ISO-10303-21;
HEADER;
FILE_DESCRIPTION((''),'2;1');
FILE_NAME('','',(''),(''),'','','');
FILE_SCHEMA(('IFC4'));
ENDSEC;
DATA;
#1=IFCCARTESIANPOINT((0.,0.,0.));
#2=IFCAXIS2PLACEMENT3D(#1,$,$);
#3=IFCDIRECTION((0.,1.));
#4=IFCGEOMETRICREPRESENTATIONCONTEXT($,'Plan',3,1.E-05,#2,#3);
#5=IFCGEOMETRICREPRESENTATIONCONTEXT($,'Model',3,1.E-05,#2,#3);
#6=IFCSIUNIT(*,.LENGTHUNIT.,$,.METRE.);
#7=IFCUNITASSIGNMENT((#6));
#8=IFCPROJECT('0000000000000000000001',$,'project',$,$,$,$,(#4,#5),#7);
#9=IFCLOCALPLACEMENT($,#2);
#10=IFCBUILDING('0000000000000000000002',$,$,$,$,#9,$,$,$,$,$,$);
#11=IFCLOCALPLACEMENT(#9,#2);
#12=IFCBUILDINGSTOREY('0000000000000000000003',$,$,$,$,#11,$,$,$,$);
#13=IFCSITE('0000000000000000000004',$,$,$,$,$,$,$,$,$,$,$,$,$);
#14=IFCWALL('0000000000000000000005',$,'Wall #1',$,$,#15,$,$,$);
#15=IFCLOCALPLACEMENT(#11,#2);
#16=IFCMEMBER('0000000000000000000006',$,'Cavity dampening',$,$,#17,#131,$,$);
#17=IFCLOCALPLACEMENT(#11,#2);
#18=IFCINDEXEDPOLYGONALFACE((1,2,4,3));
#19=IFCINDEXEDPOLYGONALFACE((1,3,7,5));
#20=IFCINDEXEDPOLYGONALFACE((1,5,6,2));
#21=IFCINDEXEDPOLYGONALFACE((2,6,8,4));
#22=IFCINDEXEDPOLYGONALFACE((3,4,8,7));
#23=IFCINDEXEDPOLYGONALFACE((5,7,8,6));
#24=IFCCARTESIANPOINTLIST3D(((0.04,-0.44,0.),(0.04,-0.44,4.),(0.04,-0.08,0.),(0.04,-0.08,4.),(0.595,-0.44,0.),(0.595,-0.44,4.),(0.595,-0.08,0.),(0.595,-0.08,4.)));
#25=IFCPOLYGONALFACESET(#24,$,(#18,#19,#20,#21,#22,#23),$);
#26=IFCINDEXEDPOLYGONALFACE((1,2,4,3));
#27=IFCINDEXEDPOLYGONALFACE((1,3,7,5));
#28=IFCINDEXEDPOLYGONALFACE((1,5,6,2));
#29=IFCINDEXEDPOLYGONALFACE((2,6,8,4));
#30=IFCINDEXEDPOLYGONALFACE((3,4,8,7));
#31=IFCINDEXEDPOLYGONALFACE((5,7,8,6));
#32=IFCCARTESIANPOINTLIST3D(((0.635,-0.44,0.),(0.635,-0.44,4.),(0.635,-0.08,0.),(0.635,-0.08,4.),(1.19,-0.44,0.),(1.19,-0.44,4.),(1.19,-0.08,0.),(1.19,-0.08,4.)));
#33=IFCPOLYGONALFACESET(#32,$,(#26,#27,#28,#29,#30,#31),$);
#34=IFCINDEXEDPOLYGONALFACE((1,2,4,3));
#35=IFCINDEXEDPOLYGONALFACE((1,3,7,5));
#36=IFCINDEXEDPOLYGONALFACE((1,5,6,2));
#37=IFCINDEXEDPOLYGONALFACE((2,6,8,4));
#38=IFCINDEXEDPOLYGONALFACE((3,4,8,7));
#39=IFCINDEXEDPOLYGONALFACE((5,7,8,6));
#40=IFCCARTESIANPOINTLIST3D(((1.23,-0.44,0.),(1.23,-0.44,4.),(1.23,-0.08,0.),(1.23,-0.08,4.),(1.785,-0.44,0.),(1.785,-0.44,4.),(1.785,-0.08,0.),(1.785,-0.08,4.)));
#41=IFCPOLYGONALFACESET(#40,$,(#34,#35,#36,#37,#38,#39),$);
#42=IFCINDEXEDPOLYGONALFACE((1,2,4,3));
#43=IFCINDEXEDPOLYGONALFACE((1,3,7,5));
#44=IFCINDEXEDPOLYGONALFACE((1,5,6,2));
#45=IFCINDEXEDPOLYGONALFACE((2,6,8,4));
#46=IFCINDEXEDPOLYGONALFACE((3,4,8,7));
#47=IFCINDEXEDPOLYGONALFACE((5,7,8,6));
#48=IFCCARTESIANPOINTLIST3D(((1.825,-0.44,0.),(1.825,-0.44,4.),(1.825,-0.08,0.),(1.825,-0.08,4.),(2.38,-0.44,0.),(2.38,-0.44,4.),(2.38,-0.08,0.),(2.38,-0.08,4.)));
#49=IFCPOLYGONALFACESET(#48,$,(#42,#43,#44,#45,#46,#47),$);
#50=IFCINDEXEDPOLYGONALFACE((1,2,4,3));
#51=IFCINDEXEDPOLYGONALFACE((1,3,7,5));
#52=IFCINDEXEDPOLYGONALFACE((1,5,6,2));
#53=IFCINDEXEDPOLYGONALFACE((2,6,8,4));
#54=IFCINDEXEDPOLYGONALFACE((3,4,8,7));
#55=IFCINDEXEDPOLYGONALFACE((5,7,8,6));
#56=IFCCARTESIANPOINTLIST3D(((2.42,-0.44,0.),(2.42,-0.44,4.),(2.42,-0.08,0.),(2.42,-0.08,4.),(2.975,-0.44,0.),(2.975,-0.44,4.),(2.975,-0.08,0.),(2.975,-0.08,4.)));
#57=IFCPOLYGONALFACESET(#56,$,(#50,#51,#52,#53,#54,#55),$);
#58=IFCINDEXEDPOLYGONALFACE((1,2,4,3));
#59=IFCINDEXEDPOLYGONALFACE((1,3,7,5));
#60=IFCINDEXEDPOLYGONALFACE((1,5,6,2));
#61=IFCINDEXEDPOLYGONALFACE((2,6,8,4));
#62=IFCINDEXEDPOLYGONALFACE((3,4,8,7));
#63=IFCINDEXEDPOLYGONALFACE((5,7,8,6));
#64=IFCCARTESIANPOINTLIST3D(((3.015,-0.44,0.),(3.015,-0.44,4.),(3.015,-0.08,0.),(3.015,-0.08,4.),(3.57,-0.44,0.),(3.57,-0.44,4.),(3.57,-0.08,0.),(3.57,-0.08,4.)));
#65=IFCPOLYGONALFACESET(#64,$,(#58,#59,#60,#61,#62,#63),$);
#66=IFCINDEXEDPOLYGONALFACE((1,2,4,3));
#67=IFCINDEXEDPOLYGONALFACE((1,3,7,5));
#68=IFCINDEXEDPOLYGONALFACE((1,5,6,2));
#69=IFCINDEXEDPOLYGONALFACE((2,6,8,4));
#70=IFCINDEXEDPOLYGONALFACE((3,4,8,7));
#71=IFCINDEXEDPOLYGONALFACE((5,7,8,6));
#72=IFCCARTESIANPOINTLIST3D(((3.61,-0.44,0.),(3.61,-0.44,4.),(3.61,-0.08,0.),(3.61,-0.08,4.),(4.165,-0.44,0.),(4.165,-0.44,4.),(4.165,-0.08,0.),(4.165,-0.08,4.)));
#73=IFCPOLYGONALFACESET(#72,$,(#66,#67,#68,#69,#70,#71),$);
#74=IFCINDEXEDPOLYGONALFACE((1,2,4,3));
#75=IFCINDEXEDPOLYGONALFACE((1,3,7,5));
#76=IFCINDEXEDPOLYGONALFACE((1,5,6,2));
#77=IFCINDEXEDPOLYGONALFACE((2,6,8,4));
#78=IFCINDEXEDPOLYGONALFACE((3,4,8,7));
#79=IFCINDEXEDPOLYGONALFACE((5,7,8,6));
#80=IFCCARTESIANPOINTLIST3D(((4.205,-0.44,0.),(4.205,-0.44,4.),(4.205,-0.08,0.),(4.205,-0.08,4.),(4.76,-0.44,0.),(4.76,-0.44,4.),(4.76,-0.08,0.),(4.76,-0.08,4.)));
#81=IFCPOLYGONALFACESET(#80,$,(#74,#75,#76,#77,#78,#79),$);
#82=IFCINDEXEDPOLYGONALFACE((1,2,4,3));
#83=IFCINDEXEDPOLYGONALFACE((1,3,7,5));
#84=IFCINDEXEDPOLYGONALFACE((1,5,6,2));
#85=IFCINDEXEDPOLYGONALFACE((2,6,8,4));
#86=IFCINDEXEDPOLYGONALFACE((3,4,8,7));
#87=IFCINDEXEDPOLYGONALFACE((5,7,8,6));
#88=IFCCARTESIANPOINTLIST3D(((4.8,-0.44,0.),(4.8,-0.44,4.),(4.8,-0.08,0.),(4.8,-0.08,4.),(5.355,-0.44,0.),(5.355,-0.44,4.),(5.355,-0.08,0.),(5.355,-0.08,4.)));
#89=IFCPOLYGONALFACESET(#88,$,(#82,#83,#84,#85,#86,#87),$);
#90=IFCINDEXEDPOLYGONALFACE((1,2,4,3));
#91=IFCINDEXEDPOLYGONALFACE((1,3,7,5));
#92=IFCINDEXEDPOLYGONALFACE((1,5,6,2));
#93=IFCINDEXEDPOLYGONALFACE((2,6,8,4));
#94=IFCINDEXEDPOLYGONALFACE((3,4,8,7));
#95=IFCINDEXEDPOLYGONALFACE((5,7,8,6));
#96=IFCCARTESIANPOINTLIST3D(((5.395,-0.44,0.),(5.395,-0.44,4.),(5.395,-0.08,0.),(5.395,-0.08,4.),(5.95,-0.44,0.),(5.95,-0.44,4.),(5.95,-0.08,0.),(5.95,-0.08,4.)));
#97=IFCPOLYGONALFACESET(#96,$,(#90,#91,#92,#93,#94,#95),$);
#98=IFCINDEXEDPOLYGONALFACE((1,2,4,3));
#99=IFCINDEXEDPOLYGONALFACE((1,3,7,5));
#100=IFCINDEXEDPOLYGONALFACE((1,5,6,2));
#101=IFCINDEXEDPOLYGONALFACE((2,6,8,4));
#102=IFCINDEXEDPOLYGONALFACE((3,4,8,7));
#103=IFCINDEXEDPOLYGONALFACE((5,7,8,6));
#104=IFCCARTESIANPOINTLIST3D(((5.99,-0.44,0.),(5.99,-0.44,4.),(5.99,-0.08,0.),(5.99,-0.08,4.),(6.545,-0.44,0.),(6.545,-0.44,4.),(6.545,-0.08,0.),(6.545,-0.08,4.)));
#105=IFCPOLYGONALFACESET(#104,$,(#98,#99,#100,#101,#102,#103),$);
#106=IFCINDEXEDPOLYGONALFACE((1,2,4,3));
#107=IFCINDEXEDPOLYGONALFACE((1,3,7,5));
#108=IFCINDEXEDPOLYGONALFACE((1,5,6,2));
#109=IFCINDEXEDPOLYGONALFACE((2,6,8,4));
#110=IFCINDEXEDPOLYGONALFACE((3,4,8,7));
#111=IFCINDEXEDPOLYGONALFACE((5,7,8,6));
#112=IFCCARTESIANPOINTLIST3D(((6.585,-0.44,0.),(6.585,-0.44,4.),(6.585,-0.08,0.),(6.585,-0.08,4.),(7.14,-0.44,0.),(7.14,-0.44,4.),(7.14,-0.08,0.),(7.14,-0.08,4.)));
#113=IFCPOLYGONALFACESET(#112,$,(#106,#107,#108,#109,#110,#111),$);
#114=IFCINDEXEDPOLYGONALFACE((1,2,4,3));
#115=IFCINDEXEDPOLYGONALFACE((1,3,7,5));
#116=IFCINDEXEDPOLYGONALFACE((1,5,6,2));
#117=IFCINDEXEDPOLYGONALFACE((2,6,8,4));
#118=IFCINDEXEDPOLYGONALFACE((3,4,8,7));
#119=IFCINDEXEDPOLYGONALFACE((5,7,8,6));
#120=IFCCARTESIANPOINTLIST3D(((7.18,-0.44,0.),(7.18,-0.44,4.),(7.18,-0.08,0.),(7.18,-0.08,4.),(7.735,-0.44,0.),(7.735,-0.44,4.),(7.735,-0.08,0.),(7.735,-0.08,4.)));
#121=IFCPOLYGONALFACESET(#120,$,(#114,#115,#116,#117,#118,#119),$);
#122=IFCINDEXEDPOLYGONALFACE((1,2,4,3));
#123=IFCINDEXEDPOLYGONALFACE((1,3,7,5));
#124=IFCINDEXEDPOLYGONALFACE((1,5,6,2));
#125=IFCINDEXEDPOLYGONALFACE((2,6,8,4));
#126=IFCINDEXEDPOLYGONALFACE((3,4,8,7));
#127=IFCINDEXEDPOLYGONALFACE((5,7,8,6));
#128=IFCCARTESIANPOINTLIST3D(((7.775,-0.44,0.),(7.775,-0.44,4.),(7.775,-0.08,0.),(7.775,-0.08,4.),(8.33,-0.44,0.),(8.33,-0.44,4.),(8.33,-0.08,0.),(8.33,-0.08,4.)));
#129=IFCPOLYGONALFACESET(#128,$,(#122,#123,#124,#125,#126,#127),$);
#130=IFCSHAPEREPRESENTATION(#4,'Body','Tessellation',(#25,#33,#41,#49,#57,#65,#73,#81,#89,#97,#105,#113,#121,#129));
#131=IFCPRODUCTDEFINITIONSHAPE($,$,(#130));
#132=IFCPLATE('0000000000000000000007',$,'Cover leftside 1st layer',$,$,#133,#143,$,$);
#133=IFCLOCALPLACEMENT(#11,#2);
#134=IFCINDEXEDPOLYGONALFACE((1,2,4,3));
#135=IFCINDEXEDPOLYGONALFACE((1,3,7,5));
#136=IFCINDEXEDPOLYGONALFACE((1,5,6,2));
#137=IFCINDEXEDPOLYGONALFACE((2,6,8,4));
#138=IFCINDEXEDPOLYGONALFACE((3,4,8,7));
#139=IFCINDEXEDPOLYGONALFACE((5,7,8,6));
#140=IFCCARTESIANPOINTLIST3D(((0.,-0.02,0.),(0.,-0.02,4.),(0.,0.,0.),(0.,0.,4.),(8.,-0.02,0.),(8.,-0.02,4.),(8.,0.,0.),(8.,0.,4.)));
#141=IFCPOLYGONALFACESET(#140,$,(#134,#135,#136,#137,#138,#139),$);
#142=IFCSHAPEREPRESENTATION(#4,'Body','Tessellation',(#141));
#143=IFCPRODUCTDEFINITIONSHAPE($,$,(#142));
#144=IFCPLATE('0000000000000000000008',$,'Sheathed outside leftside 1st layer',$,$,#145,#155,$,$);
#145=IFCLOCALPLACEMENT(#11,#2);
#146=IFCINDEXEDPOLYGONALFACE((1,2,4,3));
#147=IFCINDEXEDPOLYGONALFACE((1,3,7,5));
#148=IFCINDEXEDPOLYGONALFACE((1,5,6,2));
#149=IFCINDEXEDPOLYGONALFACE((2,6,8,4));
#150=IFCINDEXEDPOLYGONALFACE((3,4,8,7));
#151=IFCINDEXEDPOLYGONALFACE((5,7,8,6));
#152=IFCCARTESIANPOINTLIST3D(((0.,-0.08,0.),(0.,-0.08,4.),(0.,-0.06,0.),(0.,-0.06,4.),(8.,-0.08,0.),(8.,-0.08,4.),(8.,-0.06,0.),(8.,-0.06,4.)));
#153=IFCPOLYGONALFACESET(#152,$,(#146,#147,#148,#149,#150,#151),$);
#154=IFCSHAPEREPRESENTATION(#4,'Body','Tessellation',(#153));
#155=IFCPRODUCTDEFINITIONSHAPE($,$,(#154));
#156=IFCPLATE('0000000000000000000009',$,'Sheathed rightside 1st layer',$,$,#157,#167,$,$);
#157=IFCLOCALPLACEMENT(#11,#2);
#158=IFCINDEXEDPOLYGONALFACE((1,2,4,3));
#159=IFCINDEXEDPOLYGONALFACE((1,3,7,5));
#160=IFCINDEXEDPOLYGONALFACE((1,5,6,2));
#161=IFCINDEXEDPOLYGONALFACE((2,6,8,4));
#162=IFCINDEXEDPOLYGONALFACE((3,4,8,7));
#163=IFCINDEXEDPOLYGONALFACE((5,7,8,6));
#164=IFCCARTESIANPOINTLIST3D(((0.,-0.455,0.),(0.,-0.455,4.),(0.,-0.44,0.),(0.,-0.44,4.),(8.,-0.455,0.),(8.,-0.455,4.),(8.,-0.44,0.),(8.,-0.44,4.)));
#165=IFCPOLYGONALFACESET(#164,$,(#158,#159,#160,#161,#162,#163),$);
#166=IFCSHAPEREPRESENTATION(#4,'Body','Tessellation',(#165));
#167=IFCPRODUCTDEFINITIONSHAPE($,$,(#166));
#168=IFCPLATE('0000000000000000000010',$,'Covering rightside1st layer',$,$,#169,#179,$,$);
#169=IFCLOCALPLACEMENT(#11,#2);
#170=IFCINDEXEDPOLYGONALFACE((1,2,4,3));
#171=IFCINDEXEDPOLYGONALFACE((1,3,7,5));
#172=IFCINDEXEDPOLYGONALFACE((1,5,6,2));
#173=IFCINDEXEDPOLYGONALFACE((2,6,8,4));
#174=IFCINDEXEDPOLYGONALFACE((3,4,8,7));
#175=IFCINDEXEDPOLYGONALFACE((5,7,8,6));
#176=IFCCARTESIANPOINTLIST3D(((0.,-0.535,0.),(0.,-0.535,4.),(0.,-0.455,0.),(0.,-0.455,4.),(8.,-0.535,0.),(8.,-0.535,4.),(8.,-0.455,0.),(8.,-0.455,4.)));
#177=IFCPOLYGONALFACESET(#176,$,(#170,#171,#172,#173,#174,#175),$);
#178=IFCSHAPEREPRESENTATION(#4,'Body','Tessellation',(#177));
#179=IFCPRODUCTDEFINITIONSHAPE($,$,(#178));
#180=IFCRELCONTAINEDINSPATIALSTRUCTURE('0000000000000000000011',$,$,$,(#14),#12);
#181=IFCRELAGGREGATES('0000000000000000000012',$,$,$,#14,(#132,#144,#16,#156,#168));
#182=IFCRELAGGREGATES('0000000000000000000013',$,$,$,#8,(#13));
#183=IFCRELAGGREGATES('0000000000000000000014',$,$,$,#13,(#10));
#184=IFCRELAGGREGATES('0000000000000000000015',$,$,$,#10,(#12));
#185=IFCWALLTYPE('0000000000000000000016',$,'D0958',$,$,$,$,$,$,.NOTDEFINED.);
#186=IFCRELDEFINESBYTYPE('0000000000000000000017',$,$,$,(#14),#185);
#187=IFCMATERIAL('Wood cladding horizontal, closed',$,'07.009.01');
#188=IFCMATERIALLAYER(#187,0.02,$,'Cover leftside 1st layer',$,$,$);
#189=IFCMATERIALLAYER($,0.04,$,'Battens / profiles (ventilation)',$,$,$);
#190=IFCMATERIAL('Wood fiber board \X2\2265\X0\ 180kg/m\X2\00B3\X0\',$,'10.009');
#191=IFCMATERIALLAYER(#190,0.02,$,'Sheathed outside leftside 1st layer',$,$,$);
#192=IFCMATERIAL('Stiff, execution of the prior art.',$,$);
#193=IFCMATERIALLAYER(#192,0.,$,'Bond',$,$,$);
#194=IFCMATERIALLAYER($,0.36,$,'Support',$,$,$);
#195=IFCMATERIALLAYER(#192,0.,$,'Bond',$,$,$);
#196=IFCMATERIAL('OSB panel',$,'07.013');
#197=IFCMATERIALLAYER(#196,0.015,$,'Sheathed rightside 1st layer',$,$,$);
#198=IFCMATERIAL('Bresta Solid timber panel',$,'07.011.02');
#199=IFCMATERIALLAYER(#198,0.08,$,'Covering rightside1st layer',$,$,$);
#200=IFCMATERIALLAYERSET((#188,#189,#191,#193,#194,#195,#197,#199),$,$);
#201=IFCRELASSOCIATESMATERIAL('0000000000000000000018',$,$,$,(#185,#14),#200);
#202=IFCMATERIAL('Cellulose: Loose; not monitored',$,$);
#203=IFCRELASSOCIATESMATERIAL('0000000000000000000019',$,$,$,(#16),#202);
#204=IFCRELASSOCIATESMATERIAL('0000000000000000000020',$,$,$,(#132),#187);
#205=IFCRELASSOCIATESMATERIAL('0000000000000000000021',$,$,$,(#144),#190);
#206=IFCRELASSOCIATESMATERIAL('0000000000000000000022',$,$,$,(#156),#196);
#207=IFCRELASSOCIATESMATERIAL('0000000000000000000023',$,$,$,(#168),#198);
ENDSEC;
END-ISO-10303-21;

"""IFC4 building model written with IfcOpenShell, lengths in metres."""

from ifc_helpers import new_model, si_unit, direction, frame, frame_2d, origin, origin_with_axes, place, context, project, spatial, rectangle, extrude, material, layer, layer_set, type_object, element, aggregate, save


model = new_model("IFC4")

# Units and contexts
plan_context = context("Plan", 3, precision=1e-05, world=origin(), true_north=direction((0.0, 1.0)))
model_context = context("Model", 3, precision=1e-05, world=origin(), true_north=direction((0.0, 1.0)))
ifc_project = project(units=[si_unit("LENGTHUNIT", "METRE")], contexts=[plan_context, model_context])

# Site, building, storey
site = spatial("IfcSite", under=ifc_project)
building_placement = place(None, origin())
building = spatial("IfcBuilding", under=site, at=building_placement)
storey_placement = place(building_placement, origin())
storey = spatial("IfcBuildingStorey", under=building, at=storey_placement)

# Wall, member, plates
ifc_material_1 = material(Name="Wood cladding horizontal, closed", Category="07.009.01")
ifc_layer_1 = layer(ifc_material_1, 0.02, Name="Cover leftside 1st layer")
ifc_layer_2 = layer(None, 0.04, Name="Battens / profiles (ventilation)")
ifc_material_2 = material(Name="Wood fiber board ≥ 180kg/m³", Category="10.009")
ifc_layer_3 = layer(ifc_material_2, 0.02, Name="Sheathed outside leftside 1st layer")
ifc_material_3 = material(Name="Stiff, execution of the prior art.")
ifc_layer_4 = layer(ifc_material_3, 0.0, Name="Bond")
ifc_layer_5 = layer(None, 0.36, Name="Support")
ifc_layer_6 = layer(ifc_material_3, 0.0, Name="Bond")
ifc_material_4 = material(Name="OSB panel", Category="07.013")
ifc_layer_7 = layer(ifc_material_4, 0.015, Name="Sheathed rightside 1st layer")
ifc_material_5 = material(Name="Bresta Solid timber panel", Category="07.011.02")
ifc_layer_8 = layer(ifc_material_5, 0.08, Name="Covering rightside1st layer")
ifc_layer_set = layer_set([ifc_layer_1, ifc_layer_2, ifc_layer_3, ifc_layer_4, ifc_layer_5, ifc_layer_6, ifc_layer_7, ifc_layer_8])
wall_type = type_object("IfcWallType", Name="D0958", PredefinedType="NOTDEFINED", material=ifc_layer_set)
wall_placement = place(None, frame((0.0, 0.0, 0.0), z_axis=(0.0, -1.0, 0.0), x_axis=(1.0, 0.0, 0.0)))
wall = element("IfcWall", 1, at=wall_placement, inside=storey, type_object=wall_type, material=ifc_layer_set, Name="Wall #1")
ifc_material_6 = material(Name="Cellulose: Loose; not monitored")
member_1_placement = place(wall_placement, origin())
member_1 = element("IfcMember", 2, at=member_1_placement, material=ifc_material_6, Name="Cavity dampening", context=plan_context, shape_type="SweptSolid", body=[
    extrude(rectangle(XDim=0.555, YDim=0.36, at=frame_2d((0.2775, 0.18), x_axis=(1.0, 0.0))), frame((0.04, 4.0, 0.08), z_axis=(0.0, -1.0, 0.0), x_axis=(1.0, 0.0, 0.0)), (0.0, 0.0, 1.0), 4.0),
    extrude(rectangle(XDim=0.555, YDim=0.36, at=frame_2d((0.2775, 0.18), x_axis=(1.0, 0.0))), frame((0.635, 4.0, 0.08), z_axis=(0.0, -1.0, 0.0), x_axis=(1.0, 0.0, 0.0)), (0.0, 0.0, 1.0), 4.0),
    extrude(rectangle(XDim=0.555, YDim=0.36, at=frame_2d((0.2775, 0.18), x_axis=(1.0, 0.0))), frame((1.23, 4.0, 0.08), z_axis=(0.0, -1.0, 0.0), x_axis=(1.0, 0.0, 0.0)), (0.0, 0.0, 1.0), 4.0),
    extrude(rectangle(XDim=0.555, YDim=0.36, at=frame_2d((0.2775, 0.18), x_axis=(1.0, 0.0))), frame((1.825, 4.0, 0.08), z_axis=(0.0, -1.0, 0.0), x_axis=(1.0, 0.0, 0.0)), (0.0, 0.0, 1.0), 4.0),
    extrude(rectangle(XDim=0.555, YDim=0.36, at=frame_2d((0.2775, 0.18), x_axis=(1.0, 0.0))), frame((2.42, 4.0, 0.08), z_axis=(0.0, -1.0, 0.0), x_axis=(1.0, 0.0, 0.0)), (0.0, 0.0, 1.0), 4.0),
    extrude(rectangle(XDim=0.555, YDim=0.36, at=frame_2d((0.2775, 0.18), x_axis=(1.0, 0.0))), frame((3.015, 4.0, 0.08), z_axis=(0.0, -1.0, 0.0), x_axis=(1.0, 0.0, 0.0)), (0.0, 0.0, 1.0), 4.0),
    extrude(rectangle(XDim=0.555, YDim=0.36, at=frame_2d((0.2775, 0.18), x_axis=(1.0, 0.0))), frame((3.61, 4.0, 0.08), z_axis=(0.0, -1.0, 0.0), x_axis=(1.0, 0.0, 0.0)), (0.0, 0.0, 1.0), 4.0),
    extrude(rectangle(XDim=0.555, YDim=0.36, at=frame_2d((0.2775, 0.18), x_axis=(1.0, 0.0))), frame((4.205, 4.0, 0.08), z_axis=(0.0, -1.0, 0.0), x_axis=(1.0, 0.0, 0.0)), (0.0, 0.0, 1.0), 4.0),
    extrude(rectangle(XDim=0.555, YDim=0.36, at=frame_2d((0.2775, 0.18), x_axis=(1.0, 0.0))), frame((4.8, 4.0, 0.08), z_axis=(0.0, -1.0, 0.0), x_axis=(1.0, 0.0, 0.0)), (0.0, 0.0, 1.0), 4.0),
    extrude(rectangle(XDim=0.555, YDim=0.36, at=frame_2d((0.2775, 0.18), x_axis=(1.0, 0.0))), frame((5.395, 4.0, 0.08), z_axis=(0.0, -1.0, 0.0), x_axis=(1.0, 0.0, 0.0)), (0.0, 0.0, 1.0), 4.0),
    extrude(rectangle(XDim=0.555, YDim=0.36, at=frame_2d((0.2775, 0.18), x_axis=(1.0, 0.0))), frame((5.99, 4.0, 0.08), z_axis=(0.0, -1.0, 0.0), x_axis=(1.0, 0.0, 0.0)), (0.0, 0.0, 1.0), 4.0),
    extrude(rectangle(XDim=0.555, YDim=0.36, at=frame_2d((0.2775, 0.18), x_axis=(1.0, 0.0))), frame((6.585, 4.0, 0.08), z_axis=(0.0, -1.0, 0.0), x_axis=(1.0, 0.0, 0.0)), (0.0, 0.0, 1.0), 4.0),
    extrude(rectangle(XDim=0.555, YDim=0.36, at=frame_2d((0.2775, 0.18), x_axis=(1.0, 0.0))), frame((7.18, 4.0, 0.08), z_axis=(0.0, -1.0, 0.0), x_axis=(1.0, 0.0, 0.0)), (0.0, 0.0, 1.0), 4.0),
    extrude(rectangle(XDim=0.555, YDim=0.36, at=frame_2d((0.2775, 0.18), x_axis=(1.0, 0.0))), frame((7.775, 4.0, 0.08), z_axis=(0.0, -1.0, 0.0), x_axis=(1.0, 0.0, 0.0)), (0.0, 0.0, 1.0), 4.0),
])
plate_1_placement = place(wall_placement, origin())
plate_1 = element("IfcPlate", 3, at=plate_1_placement, material=ifc_material_1, Name="Cover leftside 1st layer", context=plan_context, shape_type="SweptSolid", body=[
    extrude(rectangle(XDim=8.0, YDim=4.0, at=frame_2d((4.0, 2.0), x_axis=(1.0, 0.0))), origin_with_axes(), (0.0, 0.0, 1.0), 0.02),
])
plate_2_placement = place(wall_placement, origin())
plate_2 = element("IfcPlate", 4, at=plate_2_placement, material=ifc_material_2, Name="Sheathed outside leftside 1st layer", context=plan_context, shape_type="SweptSolid", body=[
    extrude(rectangle(XDim=8.0, YDim=4.0, at=frame_2d((4.0, 2.0), x_axis=(1.0, 0.0))), frame((0.0, 0.0, 0.06), z_axis=(0.0, 0.0, 1.0), x_axis=(1.0, 0.0, 0.0)), (0.0, 0.0, 1.0), 0.02),
])
plate_3_placement = place(wall_placement, origin())
plate_3 = element("IfcPlate", 5, at=plate_3_placement, material=ifc_material_4, Name="Sheathed rightside 1st layer", context=plan_context, shape_type="SweptSolid", body=[
    extrude(rectangle(XDim=8.0, YDim=4.0, at=frame_2d((4.0, 2.0), x_axis=(1.0, 0.0))), frame((0.0, 0.0, 0.44), z_axis=(0.0, 0.0, 1.0), x_axis=(1.0, 0.0, 0.0)), (0.0, 0.0, 1.0), 0.015),
])
plate_4_placement = place(wall_placement, origin())
plate_4 = element("IfcPlate", 6, at=plate_4_placement, material=ifc_material_5, Name="Covering rightside1st layer", context=plan_context, shape_type="SweptSolid", body=[
    extrude(rectangle(XDim=8.0, YDim=4.0, at=frame_2d((4.0, 2.0), x_axis=(1.0, 0.0))), frame((0.0, 0.0, 0.455), z_axis=(0.0, 0.0, 1.0), x_axis=(1.0, 0.0, 0.0)), (0.0, 0.0, 1.0), 0.08),
])
aggregate(wall, [plate_1, plate_2, member_1, plate_3, plate_4])

save(model, "model.ifc")
